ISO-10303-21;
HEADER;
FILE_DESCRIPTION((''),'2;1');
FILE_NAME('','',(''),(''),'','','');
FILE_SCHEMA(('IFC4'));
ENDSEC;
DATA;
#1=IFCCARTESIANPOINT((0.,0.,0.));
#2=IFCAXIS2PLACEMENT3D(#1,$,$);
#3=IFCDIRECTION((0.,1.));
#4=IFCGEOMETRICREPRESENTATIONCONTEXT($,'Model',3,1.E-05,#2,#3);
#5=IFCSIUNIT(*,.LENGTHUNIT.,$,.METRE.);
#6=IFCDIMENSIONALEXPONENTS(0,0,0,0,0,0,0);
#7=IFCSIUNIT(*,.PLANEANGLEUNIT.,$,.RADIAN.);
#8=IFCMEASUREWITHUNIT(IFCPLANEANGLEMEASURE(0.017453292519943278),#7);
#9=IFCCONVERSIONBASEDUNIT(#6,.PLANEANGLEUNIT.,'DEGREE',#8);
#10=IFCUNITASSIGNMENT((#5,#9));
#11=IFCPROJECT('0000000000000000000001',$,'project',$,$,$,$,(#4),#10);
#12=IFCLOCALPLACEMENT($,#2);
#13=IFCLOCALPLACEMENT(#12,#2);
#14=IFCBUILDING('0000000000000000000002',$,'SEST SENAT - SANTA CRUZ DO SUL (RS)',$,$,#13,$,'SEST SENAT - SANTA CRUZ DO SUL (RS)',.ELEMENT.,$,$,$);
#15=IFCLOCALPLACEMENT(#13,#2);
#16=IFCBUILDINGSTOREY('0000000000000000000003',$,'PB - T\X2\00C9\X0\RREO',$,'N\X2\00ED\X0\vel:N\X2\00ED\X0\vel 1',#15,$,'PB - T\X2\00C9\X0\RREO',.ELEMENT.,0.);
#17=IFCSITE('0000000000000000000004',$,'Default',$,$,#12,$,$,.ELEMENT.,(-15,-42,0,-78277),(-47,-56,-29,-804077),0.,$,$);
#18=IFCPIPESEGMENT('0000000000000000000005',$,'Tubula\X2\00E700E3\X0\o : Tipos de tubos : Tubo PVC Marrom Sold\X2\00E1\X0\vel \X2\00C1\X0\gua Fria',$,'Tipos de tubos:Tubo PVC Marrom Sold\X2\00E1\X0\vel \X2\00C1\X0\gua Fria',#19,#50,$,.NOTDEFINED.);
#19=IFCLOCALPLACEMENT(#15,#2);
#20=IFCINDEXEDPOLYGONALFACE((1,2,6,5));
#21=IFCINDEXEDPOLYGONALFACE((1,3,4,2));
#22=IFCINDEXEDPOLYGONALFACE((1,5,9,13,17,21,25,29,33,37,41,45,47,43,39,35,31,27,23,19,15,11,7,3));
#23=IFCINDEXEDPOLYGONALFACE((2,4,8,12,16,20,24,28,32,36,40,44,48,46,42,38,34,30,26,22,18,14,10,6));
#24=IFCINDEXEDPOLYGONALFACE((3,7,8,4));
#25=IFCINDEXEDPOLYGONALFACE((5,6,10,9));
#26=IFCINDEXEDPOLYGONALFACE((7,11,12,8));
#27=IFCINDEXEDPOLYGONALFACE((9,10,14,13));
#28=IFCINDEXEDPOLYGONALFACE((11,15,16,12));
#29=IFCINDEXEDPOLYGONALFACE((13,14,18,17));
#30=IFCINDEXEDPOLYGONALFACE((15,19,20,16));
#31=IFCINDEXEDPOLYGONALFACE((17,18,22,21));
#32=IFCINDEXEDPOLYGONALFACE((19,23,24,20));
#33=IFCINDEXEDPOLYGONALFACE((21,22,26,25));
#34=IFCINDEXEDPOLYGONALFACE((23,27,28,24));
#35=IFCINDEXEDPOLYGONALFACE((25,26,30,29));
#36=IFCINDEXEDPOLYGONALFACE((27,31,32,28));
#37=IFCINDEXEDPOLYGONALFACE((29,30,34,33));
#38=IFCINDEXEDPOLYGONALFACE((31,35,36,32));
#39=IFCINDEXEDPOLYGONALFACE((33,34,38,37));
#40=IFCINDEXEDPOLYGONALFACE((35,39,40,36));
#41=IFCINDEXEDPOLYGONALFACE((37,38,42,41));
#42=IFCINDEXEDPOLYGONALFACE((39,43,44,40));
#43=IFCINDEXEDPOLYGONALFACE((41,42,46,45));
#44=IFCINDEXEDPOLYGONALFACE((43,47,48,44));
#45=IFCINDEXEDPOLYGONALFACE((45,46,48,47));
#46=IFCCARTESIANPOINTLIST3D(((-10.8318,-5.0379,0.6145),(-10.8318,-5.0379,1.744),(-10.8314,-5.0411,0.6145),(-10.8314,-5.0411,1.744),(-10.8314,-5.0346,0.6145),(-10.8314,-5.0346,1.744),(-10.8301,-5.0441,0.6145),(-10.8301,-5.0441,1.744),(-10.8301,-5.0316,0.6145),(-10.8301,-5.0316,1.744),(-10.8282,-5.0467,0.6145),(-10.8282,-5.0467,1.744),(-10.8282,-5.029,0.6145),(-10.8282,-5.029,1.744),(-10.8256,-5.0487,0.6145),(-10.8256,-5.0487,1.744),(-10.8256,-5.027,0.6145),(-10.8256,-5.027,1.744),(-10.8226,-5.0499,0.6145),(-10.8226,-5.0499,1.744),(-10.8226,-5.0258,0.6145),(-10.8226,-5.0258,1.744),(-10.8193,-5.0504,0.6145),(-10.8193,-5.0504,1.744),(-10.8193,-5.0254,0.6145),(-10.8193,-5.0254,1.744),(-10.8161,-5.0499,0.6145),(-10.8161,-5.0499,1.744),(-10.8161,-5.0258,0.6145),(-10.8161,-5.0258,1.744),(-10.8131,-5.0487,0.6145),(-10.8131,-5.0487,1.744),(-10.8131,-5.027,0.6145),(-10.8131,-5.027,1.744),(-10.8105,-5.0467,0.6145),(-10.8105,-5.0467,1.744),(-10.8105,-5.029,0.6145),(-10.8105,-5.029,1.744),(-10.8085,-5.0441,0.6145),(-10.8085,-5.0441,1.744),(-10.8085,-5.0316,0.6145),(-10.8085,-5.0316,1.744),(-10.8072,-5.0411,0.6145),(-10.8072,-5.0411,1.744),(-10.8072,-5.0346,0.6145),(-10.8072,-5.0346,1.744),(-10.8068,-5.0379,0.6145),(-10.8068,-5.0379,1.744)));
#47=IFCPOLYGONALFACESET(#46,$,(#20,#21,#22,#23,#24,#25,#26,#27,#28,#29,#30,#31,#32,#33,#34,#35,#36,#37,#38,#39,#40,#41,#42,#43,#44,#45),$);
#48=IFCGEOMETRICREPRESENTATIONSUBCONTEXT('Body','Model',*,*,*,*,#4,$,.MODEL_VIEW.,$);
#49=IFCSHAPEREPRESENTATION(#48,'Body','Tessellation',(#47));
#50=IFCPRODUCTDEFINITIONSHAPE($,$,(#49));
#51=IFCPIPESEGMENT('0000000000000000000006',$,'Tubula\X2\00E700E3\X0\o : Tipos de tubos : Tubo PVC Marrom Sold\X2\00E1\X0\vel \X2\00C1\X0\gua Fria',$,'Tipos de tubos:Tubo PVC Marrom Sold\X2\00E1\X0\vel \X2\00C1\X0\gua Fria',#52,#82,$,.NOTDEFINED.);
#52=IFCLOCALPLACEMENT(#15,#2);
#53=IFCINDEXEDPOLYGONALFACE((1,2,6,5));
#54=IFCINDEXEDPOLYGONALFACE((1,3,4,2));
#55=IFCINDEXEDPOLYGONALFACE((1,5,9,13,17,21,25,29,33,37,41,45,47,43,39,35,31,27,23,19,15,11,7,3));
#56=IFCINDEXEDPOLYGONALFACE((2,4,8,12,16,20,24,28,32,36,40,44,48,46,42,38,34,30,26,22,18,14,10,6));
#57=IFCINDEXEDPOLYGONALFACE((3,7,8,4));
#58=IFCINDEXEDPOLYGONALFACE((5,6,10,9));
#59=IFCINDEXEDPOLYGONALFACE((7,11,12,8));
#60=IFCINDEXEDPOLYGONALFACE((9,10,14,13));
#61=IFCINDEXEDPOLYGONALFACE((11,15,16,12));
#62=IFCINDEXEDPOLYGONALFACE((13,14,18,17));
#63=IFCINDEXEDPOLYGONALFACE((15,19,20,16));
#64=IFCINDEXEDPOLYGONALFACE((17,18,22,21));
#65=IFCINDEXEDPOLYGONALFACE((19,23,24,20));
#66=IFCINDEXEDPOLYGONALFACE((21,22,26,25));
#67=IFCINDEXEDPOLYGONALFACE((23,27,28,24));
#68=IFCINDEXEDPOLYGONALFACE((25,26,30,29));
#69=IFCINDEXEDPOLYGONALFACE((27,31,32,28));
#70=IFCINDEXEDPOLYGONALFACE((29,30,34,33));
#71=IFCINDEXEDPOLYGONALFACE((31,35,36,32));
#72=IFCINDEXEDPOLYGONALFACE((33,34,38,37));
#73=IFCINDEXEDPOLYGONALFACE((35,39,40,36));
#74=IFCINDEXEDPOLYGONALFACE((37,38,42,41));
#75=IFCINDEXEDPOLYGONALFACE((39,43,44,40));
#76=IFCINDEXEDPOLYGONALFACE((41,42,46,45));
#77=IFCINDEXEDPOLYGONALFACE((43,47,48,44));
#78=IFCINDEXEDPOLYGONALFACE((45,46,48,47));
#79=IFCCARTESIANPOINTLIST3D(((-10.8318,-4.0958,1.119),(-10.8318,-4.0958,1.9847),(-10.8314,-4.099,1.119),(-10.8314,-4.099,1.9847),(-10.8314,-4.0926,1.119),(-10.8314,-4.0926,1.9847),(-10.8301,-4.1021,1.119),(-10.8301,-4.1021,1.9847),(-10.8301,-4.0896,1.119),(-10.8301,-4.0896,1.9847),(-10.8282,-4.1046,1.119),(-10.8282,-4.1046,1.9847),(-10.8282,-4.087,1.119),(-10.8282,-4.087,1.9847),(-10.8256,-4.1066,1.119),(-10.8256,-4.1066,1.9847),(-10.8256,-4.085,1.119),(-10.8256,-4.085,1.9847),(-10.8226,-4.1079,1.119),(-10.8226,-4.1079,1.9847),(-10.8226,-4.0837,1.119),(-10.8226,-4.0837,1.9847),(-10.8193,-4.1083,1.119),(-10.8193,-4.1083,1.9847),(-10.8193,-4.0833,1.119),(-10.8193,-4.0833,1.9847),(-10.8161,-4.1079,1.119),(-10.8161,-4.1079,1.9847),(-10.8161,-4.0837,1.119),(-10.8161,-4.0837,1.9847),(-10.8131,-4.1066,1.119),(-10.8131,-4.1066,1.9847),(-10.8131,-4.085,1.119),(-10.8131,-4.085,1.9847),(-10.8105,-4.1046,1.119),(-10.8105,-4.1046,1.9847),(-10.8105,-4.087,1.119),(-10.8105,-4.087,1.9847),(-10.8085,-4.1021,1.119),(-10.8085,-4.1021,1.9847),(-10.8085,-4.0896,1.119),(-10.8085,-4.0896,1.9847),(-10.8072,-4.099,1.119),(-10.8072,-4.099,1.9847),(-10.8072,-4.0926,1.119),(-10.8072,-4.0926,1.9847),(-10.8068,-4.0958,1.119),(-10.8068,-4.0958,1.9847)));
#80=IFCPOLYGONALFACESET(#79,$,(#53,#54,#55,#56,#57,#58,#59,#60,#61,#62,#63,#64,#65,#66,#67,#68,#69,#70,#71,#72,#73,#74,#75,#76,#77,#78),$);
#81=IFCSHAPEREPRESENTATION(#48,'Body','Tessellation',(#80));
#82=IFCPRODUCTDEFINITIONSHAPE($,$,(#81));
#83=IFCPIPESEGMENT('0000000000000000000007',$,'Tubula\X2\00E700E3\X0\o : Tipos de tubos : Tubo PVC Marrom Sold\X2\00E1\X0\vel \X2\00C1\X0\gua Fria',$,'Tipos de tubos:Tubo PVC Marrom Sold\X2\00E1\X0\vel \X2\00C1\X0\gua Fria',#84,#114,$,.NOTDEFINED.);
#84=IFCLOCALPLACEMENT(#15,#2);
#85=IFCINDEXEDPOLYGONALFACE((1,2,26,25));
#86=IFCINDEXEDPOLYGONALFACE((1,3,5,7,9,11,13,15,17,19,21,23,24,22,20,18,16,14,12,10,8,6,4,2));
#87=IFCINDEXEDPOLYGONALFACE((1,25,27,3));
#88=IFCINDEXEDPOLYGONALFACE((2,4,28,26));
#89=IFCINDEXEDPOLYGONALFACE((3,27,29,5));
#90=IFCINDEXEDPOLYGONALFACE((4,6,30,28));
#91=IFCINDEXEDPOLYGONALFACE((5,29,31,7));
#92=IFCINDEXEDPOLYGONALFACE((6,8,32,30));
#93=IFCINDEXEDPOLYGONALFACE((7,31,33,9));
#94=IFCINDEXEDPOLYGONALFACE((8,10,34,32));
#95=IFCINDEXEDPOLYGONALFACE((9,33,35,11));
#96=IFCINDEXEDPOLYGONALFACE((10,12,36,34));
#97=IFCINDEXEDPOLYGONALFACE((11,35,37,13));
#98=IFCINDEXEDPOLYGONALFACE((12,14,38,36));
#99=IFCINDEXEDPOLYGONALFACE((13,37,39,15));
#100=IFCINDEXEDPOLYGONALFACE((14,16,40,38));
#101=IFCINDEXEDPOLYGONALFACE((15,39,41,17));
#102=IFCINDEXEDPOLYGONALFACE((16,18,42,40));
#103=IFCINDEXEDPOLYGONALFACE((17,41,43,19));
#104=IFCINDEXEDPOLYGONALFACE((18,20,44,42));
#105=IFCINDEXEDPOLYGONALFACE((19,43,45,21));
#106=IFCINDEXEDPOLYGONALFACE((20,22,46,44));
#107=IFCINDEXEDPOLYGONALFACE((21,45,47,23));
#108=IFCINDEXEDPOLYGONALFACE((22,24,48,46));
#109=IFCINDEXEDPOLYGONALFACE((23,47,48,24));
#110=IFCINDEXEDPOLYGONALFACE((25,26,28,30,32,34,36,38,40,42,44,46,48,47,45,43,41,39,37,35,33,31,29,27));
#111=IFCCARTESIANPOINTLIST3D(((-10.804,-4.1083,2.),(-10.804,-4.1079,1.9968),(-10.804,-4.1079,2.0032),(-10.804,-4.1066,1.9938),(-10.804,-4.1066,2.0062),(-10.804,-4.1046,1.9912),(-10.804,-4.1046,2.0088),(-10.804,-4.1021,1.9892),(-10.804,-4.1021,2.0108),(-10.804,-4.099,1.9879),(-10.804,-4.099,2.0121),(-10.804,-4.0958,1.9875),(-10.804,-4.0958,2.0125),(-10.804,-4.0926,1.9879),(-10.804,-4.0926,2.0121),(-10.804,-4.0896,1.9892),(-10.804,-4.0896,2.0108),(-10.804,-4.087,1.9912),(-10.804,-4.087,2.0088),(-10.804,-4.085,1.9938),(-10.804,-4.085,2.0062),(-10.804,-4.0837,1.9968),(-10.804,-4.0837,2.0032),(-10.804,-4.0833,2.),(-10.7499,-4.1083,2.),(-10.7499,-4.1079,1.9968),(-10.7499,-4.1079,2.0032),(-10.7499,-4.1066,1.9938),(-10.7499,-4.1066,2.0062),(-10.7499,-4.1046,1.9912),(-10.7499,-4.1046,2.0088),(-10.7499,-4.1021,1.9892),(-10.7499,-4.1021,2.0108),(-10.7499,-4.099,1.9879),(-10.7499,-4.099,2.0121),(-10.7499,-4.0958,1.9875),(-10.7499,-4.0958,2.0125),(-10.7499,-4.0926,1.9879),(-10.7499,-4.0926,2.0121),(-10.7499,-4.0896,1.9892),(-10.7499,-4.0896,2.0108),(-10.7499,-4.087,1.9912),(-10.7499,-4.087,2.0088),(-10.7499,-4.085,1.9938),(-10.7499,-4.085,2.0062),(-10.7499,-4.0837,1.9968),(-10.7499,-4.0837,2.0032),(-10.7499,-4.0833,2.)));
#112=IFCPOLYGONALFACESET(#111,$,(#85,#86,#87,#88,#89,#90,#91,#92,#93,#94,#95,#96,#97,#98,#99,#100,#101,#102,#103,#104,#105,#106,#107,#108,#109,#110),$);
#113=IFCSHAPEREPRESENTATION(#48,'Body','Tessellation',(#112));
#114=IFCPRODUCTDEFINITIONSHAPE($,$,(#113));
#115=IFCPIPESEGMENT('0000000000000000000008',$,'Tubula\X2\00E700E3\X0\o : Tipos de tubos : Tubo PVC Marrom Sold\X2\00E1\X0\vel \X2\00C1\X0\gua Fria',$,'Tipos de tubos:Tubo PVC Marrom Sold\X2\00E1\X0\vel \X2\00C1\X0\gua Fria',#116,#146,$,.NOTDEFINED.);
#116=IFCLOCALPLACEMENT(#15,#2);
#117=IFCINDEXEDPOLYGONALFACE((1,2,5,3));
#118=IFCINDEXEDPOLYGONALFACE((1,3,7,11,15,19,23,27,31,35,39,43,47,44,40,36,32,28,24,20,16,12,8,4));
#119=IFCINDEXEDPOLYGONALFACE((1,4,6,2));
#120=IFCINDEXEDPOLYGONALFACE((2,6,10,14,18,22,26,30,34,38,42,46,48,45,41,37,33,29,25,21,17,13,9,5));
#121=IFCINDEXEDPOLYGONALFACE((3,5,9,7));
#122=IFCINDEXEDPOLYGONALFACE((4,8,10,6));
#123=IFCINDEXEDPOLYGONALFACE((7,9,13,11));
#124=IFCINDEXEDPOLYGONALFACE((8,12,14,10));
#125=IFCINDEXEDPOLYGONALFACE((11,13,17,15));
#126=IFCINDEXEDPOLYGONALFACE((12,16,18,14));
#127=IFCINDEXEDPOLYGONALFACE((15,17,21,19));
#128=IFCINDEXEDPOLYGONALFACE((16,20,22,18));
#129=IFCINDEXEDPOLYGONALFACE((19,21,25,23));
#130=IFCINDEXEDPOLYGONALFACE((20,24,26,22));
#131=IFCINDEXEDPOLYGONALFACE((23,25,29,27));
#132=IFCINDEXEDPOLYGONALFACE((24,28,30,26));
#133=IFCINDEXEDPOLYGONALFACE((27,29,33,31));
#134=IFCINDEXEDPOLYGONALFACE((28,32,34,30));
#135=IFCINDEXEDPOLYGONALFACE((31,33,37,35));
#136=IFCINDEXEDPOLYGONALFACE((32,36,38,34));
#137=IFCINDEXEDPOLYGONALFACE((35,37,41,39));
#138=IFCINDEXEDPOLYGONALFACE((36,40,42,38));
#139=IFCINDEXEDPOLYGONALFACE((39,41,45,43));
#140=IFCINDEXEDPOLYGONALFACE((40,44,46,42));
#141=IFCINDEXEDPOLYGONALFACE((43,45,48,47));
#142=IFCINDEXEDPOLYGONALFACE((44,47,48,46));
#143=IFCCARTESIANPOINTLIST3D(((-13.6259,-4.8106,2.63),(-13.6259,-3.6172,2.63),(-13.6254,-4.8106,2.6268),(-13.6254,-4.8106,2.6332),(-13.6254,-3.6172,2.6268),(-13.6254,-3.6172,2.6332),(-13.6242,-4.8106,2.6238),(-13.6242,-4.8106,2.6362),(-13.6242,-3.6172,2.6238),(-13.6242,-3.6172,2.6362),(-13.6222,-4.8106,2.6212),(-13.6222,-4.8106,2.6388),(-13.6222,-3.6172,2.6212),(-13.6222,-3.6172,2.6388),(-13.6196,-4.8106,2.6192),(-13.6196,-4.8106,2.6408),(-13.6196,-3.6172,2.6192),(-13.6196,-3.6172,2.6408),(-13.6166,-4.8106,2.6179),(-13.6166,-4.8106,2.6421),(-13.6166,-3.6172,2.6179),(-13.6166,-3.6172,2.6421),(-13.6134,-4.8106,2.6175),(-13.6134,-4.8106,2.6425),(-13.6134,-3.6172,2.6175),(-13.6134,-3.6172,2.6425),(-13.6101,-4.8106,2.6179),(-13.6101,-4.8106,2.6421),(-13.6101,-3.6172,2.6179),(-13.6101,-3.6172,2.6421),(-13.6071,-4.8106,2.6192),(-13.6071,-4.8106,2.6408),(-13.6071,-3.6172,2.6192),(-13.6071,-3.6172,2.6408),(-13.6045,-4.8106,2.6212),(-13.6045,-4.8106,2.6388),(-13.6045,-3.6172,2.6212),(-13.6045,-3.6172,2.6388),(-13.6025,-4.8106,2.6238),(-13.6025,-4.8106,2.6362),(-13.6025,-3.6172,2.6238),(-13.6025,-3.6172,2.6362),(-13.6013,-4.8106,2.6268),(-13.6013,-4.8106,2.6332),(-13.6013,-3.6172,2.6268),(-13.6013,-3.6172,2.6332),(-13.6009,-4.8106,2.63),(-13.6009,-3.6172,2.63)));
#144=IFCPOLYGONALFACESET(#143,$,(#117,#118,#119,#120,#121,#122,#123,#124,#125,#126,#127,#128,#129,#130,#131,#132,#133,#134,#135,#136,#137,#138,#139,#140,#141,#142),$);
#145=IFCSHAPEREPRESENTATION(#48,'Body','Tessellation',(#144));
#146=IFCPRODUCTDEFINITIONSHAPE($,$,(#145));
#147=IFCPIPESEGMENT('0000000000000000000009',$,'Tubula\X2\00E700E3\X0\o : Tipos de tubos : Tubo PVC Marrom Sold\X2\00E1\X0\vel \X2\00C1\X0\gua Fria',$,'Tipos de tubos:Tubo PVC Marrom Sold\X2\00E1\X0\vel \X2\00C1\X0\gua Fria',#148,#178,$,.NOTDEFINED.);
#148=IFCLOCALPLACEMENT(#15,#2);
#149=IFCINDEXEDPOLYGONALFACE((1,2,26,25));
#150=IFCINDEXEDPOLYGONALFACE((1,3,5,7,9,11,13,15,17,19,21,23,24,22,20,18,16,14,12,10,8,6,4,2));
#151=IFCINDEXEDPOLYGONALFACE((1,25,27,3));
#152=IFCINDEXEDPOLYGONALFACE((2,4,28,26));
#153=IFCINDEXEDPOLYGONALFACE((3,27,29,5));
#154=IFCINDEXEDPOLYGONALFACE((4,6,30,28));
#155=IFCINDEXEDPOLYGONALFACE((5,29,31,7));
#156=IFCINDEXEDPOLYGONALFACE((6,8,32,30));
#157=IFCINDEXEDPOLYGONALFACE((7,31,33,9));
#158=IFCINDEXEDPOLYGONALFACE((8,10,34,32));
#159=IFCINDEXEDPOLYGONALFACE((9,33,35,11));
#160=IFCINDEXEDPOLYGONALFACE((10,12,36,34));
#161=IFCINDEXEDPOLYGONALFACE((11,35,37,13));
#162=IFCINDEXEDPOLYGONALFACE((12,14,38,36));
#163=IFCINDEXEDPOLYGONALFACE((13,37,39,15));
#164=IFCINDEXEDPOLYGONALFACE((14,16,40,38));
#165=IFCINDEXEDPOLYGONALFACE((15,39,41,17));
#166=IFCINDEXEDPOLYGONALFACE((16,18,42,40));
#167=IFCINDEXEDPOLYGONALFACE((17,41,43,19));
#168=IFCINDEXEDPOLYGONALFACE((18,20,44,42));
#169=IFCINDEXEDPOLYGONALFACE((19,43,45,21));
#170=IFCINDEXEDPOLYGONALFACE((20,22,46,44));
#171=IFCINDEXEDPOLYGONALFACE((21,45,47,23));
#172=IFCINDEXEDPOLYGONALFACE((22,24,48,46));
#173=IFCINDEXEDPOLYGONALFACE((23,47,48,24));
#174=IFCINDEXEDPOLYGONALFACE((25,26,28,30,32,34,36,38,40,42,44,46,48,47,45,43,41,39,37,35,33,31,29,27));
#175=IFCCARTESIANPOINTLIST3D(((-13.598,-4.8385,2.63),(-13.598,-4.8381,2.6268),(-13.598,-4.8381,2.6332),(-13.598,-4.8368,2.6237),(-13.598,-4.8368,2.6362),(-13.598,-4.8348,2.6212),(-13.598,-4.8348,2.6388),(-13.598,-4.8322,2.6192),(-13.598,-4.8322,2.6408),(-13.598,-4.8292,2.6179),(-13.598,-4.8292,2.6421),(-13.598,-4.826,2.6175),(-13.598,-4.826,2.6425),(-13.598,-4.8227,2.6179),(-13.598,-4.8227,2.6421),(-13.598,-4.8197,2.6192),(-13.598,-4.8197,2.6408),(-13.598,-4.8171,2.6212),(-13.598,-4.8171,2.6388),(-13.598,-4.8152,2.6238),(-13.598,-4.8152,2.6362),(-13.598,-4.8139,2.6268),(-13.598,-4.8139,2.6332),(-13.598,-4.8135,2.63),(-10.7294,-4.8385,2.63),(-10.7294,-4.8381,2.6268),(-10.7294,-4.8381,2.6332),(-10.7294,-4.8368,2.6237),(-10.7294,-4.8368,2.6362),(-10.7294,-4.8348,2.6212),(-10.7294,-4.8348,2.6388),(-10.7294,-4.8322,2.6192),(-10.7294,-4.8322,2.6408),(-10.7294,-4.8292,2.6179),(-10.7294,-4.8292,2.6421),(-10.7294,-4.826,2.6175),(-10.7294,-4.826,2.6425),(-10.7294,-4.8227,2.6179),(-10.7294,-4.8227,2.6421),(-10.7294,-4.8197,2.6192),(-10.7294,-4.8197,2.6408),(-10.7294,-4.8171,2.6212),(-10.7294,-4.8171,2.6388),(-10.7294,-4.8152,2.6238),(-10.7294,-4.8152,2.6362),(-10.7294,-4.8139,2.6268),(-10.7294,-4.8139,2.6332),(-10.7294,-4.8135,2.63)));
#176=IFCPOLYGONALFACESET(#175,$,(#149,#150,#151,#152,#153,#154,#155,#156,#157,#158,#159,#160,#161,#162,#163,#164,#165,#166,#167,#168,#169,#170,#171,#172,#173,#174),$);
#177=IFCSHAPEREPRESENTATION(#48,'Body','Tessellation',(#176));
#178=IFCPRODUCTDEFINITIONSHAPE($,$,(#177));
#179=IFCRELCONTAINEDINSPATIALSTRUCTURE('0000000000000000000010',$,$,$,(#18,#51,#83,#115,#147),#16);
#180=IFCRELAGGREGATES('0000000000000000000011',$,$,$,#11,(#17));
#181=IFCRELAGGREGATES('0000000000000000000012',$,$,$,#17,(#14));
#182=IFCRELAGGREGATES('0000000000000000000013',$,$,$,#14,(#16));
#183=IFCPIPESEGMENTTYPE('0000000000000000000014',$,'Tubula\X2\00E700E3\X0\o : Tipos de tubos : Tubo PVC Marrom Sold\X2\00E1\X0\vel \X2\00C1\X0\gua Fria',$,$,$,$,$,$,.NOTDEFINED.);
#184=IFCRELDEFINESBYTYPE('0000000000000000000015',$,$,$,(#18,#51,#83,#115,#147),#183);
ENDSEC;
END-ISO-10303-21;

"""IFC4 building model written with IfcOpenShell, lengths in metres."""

from ifc_helpers import new_model, entity, si_unit, converted_unit, direction, frame, origin, place, context, subcontext, project, spatial, arc, indexed_curve, outline, extrude, type_object, element, save


model = new_model("IFC4")

# Units and contexts
model_context = context("Model", 3, precision=1e-05, world=origin(), true_north=direction((0.0, 1.0)))
body_context = subcontext(model_context, "Body", "Model", "MODEL_VIEW")
ifc_project = project(units=[si_unit("LENGTHUNIT", "METRE"), converted_unit("PLANEANGLEUNIT", "DEGREE", entity("IfcPlaneAngleMeasure", 0.017453292519943278), si_unit("PLANEANGLEUNIT", "RADIAN"), dimensions=[0, 0, 0, 0, 0, 0, 0])], contexts=[model_context])

# Site, building, storey
site_placement = place(None, origin())
site = spatial("IfcSite", under=ifc_project, at=site_placement, Name="Default", CompositionType="ELEMENT", RefLatitude=(-15, -42, 0, -78277), RefLongitude=(-47, -56, -29, -804077), RefElevation=0.0)
building_placement = place(site_placement, origin())
building = spatial("IfcBuilding", under=site, at=building_placement, Name="SEST SENAT - SANTA CRUZ DO SUL (RS)", LongName="SEST SENAT - SANTA CRUZ DO SUL (RS)", CompositionType="ELEMENT")
storey_placement = place(building_placement, origin())
storey = spatial("IfcBuildingStorey", under=building, at=storey_placement, Name="PB - TÉRREO", ObjectType="Nível:Nível 1", LongName="PB - TÉRREO", CompositionType="ELEMENT", Elevation=0.0)

# Pipe segments
pipe_segment_type_1 = type_object("IfcPipeSegmentType", Name="Tubulação : Tipos de tubos : Tubo PVC Marrom Soldável Água Fria", PredefinedType="NOTDEFINED")
pipe_segment_1_placement = place(storey_placement, frame((-10.8334, -5.052, 0.6145)))
element("IfcPipeSegment", 1, at=pipe_segment_1_placement, inside=storey, type_object=pipe_segment_type_1, Name="Tubulação : Tipos de tubos : Tubo PVC Marrom Soldável Água Fria", ObjectType="Tipos de tubos:Tubo PVC Marrom Soldável Água Fria", PredefinedType="NOTDEFINED", context=body_context, shape_type="SweptSolid", body=[
    extrude(outline(indexed_curve([(0.0125, 0.0), (0.0088, 0.0088), (0.0, 0.0125), (-0.0088, 0.0088), (-0.0125, 0.0), (-0.0088, -0.0088), (0.0, -0.0125), (0.0088, -0.0088)], segments=[arc(1, 2, 3), arc(3, 4, 5), arc(5, 6, 7), arc(7, 8, 1)], self_intersect=False)), frame((0.0141, 0.0141, 0.0)), (0.0, 0.0, 1.0), 1.1295),
])
pipe_segment_2_placement = place(storey_placement, frame((-10.8334, -4.1099, 1.119)))
element("IfcPipeSegment", 2, at=pipe_segment_2_placement, inside=storey, type_object=pipe_segment_type_1, Name="Tubulação : Tipos de tubos : Tubo PVC Marrom Soldável Água Fria", ObjectType="Tipos de tubos:Tubo PVC Marrom Soldável Água Fria", PredefinedType="NOTDEFINED", context=body_context, shape_type="SweptSolid", body=[
    extrude(outline(indexed_curve([(0.0125, 0.0), (0.0088, 0.0088), (0.0, 0.0125), (-0.0088, 0.0088), (-0.0125, 0.0), (-0.0088, -0.0088), (0.0, -0.0125), (0.0088, -0.0088)], segments=[arc(1, 2, 3), arc(3, 4, 5), arc(5, 6, 7), arc(7, 8, 1)], self_intersect=False)), frame((0.0141, 0.0141, 0.0), z_axis=(0.0, 0.0, 1.0), x_axis=(-1.0, 0.0, 0.0)), (0.0, 0.0, 1.0), 0.8657),
])
pipe_segment_3_placement = place(storey_placement, frame((-10.804, -4.1099, 1.9859)))
element("IfcPipeSegment", 3, at=pipe_segment_3_placement, inside=storey, type_object=pipe_segment_type_1, Name="Tubulação : Tipos de tubos : Tubo PVC Marrom Soldável Água Fria", ObjectType="Tipos de tubos:Tubo PVC Marrom Soldável Água Fria", PredefinedType="NOTDEFINED", context=body_context, shape_type="SweptSolid", body=[
    extrude(outline(indexed_curve([(0.0125, 0.0), (0.0088, 0.0088), (0.0, 0.0125), (-0.0088, 0.0088), (-0.0125, 0.0), (-0.0088, -0.0088), (0.0, -0.0125), (0.0088, -0.0088)], segments=[arc(1, 2, 3), arc(3, 4, 5), arc(5, 6, 7), arc(7, 8, 1)], self_intersect=False)), frame((0.0, 0.0141, 0.0141), z_axis=(1.0, 0.0, 0.0), x_axis=(0.0, -1.0, 0.0)), (0.0, 0.0, 1.0), 0.0541),
])
pipe_segment_4_placement = place(storey_placement, frame((-13.6275, -4.8106, 2.6159)))
element("IfcPipeSegment", 4, at=pipe_segment_4_placement, inside=storey, type_object=pipe_segment_type_1, Name="Tubulação : Tipos de tubos : Tubo PVC Marrom Soldável Água Fria", ObjectType="Tipos de tubos:Tubo PVC Marrom Soldável Água Fria", PredefinedType="NOTDEFINED", context=body_context, shape_type="SweptSolid", body=[
    extrude(outline(indexed_curve([(0.0125, 0.0), (0.0088, 0.0088), (0.0, 0.0125), (-0.0088, 0.0088), (-0.0125, 0.0), (-0.0088, -0.0088), (0.0, -0.0125), (0.0088, -0.0088)], segments=[arc(1, 2, 3), arc(3, 4, 5), arc(5, 6, 7), arc(7, 8, 1)], self_intersect=False)), frame((0.0141, 0.0, 0.0141), z_axis=(0.0, 1.0, 0.0), x_axis=(1.0, 0.0, 0.0)), (0.0, 0.0, 1.0), 1.1934),
])
pipe_segment_5_placement = place(storey_placement, frame((-13.598, -4.8401, 2.6159)))
element("IfcPipeSegment", 5, at=pipe_segment_5_placement, inside=storey, type_object=pipe_segment_type_1, Name="Tubulação : Tipos de tubos : Tubo PVC Marrom Soldável Água Fria", ObjectType="Tipos de tubos:Tubo PVC Marrom Soldável Água Fria", PredefinedType="NOTDEFINED", context=body_context, shape_type="SweptSolid", body=[
    extrude(outline(indexed_curve([(0.0125, 0.0), (0.0088, 0.0088), (0.0, 0.0125), (-0.0088, 0.0088), (-0.0125, 0.0), (-0.0088, -0.0088), (0.0, -0.0125), (0.0088, -0.0088)], segments=[arc(1, 2, 3), arc(3, 4, 5), arc(5, 6, 7), arc(7, 8, 1)], self_intersect=False)), frame((0.0, 0.0141, 0.0141), z_axis=(1.0, 0.0, 0.0), x_axis=(0.0, 1.0, 0.0)), (0.0, 0.0, 1.0), 2.8685),
])

save(model, "model.ifc")
